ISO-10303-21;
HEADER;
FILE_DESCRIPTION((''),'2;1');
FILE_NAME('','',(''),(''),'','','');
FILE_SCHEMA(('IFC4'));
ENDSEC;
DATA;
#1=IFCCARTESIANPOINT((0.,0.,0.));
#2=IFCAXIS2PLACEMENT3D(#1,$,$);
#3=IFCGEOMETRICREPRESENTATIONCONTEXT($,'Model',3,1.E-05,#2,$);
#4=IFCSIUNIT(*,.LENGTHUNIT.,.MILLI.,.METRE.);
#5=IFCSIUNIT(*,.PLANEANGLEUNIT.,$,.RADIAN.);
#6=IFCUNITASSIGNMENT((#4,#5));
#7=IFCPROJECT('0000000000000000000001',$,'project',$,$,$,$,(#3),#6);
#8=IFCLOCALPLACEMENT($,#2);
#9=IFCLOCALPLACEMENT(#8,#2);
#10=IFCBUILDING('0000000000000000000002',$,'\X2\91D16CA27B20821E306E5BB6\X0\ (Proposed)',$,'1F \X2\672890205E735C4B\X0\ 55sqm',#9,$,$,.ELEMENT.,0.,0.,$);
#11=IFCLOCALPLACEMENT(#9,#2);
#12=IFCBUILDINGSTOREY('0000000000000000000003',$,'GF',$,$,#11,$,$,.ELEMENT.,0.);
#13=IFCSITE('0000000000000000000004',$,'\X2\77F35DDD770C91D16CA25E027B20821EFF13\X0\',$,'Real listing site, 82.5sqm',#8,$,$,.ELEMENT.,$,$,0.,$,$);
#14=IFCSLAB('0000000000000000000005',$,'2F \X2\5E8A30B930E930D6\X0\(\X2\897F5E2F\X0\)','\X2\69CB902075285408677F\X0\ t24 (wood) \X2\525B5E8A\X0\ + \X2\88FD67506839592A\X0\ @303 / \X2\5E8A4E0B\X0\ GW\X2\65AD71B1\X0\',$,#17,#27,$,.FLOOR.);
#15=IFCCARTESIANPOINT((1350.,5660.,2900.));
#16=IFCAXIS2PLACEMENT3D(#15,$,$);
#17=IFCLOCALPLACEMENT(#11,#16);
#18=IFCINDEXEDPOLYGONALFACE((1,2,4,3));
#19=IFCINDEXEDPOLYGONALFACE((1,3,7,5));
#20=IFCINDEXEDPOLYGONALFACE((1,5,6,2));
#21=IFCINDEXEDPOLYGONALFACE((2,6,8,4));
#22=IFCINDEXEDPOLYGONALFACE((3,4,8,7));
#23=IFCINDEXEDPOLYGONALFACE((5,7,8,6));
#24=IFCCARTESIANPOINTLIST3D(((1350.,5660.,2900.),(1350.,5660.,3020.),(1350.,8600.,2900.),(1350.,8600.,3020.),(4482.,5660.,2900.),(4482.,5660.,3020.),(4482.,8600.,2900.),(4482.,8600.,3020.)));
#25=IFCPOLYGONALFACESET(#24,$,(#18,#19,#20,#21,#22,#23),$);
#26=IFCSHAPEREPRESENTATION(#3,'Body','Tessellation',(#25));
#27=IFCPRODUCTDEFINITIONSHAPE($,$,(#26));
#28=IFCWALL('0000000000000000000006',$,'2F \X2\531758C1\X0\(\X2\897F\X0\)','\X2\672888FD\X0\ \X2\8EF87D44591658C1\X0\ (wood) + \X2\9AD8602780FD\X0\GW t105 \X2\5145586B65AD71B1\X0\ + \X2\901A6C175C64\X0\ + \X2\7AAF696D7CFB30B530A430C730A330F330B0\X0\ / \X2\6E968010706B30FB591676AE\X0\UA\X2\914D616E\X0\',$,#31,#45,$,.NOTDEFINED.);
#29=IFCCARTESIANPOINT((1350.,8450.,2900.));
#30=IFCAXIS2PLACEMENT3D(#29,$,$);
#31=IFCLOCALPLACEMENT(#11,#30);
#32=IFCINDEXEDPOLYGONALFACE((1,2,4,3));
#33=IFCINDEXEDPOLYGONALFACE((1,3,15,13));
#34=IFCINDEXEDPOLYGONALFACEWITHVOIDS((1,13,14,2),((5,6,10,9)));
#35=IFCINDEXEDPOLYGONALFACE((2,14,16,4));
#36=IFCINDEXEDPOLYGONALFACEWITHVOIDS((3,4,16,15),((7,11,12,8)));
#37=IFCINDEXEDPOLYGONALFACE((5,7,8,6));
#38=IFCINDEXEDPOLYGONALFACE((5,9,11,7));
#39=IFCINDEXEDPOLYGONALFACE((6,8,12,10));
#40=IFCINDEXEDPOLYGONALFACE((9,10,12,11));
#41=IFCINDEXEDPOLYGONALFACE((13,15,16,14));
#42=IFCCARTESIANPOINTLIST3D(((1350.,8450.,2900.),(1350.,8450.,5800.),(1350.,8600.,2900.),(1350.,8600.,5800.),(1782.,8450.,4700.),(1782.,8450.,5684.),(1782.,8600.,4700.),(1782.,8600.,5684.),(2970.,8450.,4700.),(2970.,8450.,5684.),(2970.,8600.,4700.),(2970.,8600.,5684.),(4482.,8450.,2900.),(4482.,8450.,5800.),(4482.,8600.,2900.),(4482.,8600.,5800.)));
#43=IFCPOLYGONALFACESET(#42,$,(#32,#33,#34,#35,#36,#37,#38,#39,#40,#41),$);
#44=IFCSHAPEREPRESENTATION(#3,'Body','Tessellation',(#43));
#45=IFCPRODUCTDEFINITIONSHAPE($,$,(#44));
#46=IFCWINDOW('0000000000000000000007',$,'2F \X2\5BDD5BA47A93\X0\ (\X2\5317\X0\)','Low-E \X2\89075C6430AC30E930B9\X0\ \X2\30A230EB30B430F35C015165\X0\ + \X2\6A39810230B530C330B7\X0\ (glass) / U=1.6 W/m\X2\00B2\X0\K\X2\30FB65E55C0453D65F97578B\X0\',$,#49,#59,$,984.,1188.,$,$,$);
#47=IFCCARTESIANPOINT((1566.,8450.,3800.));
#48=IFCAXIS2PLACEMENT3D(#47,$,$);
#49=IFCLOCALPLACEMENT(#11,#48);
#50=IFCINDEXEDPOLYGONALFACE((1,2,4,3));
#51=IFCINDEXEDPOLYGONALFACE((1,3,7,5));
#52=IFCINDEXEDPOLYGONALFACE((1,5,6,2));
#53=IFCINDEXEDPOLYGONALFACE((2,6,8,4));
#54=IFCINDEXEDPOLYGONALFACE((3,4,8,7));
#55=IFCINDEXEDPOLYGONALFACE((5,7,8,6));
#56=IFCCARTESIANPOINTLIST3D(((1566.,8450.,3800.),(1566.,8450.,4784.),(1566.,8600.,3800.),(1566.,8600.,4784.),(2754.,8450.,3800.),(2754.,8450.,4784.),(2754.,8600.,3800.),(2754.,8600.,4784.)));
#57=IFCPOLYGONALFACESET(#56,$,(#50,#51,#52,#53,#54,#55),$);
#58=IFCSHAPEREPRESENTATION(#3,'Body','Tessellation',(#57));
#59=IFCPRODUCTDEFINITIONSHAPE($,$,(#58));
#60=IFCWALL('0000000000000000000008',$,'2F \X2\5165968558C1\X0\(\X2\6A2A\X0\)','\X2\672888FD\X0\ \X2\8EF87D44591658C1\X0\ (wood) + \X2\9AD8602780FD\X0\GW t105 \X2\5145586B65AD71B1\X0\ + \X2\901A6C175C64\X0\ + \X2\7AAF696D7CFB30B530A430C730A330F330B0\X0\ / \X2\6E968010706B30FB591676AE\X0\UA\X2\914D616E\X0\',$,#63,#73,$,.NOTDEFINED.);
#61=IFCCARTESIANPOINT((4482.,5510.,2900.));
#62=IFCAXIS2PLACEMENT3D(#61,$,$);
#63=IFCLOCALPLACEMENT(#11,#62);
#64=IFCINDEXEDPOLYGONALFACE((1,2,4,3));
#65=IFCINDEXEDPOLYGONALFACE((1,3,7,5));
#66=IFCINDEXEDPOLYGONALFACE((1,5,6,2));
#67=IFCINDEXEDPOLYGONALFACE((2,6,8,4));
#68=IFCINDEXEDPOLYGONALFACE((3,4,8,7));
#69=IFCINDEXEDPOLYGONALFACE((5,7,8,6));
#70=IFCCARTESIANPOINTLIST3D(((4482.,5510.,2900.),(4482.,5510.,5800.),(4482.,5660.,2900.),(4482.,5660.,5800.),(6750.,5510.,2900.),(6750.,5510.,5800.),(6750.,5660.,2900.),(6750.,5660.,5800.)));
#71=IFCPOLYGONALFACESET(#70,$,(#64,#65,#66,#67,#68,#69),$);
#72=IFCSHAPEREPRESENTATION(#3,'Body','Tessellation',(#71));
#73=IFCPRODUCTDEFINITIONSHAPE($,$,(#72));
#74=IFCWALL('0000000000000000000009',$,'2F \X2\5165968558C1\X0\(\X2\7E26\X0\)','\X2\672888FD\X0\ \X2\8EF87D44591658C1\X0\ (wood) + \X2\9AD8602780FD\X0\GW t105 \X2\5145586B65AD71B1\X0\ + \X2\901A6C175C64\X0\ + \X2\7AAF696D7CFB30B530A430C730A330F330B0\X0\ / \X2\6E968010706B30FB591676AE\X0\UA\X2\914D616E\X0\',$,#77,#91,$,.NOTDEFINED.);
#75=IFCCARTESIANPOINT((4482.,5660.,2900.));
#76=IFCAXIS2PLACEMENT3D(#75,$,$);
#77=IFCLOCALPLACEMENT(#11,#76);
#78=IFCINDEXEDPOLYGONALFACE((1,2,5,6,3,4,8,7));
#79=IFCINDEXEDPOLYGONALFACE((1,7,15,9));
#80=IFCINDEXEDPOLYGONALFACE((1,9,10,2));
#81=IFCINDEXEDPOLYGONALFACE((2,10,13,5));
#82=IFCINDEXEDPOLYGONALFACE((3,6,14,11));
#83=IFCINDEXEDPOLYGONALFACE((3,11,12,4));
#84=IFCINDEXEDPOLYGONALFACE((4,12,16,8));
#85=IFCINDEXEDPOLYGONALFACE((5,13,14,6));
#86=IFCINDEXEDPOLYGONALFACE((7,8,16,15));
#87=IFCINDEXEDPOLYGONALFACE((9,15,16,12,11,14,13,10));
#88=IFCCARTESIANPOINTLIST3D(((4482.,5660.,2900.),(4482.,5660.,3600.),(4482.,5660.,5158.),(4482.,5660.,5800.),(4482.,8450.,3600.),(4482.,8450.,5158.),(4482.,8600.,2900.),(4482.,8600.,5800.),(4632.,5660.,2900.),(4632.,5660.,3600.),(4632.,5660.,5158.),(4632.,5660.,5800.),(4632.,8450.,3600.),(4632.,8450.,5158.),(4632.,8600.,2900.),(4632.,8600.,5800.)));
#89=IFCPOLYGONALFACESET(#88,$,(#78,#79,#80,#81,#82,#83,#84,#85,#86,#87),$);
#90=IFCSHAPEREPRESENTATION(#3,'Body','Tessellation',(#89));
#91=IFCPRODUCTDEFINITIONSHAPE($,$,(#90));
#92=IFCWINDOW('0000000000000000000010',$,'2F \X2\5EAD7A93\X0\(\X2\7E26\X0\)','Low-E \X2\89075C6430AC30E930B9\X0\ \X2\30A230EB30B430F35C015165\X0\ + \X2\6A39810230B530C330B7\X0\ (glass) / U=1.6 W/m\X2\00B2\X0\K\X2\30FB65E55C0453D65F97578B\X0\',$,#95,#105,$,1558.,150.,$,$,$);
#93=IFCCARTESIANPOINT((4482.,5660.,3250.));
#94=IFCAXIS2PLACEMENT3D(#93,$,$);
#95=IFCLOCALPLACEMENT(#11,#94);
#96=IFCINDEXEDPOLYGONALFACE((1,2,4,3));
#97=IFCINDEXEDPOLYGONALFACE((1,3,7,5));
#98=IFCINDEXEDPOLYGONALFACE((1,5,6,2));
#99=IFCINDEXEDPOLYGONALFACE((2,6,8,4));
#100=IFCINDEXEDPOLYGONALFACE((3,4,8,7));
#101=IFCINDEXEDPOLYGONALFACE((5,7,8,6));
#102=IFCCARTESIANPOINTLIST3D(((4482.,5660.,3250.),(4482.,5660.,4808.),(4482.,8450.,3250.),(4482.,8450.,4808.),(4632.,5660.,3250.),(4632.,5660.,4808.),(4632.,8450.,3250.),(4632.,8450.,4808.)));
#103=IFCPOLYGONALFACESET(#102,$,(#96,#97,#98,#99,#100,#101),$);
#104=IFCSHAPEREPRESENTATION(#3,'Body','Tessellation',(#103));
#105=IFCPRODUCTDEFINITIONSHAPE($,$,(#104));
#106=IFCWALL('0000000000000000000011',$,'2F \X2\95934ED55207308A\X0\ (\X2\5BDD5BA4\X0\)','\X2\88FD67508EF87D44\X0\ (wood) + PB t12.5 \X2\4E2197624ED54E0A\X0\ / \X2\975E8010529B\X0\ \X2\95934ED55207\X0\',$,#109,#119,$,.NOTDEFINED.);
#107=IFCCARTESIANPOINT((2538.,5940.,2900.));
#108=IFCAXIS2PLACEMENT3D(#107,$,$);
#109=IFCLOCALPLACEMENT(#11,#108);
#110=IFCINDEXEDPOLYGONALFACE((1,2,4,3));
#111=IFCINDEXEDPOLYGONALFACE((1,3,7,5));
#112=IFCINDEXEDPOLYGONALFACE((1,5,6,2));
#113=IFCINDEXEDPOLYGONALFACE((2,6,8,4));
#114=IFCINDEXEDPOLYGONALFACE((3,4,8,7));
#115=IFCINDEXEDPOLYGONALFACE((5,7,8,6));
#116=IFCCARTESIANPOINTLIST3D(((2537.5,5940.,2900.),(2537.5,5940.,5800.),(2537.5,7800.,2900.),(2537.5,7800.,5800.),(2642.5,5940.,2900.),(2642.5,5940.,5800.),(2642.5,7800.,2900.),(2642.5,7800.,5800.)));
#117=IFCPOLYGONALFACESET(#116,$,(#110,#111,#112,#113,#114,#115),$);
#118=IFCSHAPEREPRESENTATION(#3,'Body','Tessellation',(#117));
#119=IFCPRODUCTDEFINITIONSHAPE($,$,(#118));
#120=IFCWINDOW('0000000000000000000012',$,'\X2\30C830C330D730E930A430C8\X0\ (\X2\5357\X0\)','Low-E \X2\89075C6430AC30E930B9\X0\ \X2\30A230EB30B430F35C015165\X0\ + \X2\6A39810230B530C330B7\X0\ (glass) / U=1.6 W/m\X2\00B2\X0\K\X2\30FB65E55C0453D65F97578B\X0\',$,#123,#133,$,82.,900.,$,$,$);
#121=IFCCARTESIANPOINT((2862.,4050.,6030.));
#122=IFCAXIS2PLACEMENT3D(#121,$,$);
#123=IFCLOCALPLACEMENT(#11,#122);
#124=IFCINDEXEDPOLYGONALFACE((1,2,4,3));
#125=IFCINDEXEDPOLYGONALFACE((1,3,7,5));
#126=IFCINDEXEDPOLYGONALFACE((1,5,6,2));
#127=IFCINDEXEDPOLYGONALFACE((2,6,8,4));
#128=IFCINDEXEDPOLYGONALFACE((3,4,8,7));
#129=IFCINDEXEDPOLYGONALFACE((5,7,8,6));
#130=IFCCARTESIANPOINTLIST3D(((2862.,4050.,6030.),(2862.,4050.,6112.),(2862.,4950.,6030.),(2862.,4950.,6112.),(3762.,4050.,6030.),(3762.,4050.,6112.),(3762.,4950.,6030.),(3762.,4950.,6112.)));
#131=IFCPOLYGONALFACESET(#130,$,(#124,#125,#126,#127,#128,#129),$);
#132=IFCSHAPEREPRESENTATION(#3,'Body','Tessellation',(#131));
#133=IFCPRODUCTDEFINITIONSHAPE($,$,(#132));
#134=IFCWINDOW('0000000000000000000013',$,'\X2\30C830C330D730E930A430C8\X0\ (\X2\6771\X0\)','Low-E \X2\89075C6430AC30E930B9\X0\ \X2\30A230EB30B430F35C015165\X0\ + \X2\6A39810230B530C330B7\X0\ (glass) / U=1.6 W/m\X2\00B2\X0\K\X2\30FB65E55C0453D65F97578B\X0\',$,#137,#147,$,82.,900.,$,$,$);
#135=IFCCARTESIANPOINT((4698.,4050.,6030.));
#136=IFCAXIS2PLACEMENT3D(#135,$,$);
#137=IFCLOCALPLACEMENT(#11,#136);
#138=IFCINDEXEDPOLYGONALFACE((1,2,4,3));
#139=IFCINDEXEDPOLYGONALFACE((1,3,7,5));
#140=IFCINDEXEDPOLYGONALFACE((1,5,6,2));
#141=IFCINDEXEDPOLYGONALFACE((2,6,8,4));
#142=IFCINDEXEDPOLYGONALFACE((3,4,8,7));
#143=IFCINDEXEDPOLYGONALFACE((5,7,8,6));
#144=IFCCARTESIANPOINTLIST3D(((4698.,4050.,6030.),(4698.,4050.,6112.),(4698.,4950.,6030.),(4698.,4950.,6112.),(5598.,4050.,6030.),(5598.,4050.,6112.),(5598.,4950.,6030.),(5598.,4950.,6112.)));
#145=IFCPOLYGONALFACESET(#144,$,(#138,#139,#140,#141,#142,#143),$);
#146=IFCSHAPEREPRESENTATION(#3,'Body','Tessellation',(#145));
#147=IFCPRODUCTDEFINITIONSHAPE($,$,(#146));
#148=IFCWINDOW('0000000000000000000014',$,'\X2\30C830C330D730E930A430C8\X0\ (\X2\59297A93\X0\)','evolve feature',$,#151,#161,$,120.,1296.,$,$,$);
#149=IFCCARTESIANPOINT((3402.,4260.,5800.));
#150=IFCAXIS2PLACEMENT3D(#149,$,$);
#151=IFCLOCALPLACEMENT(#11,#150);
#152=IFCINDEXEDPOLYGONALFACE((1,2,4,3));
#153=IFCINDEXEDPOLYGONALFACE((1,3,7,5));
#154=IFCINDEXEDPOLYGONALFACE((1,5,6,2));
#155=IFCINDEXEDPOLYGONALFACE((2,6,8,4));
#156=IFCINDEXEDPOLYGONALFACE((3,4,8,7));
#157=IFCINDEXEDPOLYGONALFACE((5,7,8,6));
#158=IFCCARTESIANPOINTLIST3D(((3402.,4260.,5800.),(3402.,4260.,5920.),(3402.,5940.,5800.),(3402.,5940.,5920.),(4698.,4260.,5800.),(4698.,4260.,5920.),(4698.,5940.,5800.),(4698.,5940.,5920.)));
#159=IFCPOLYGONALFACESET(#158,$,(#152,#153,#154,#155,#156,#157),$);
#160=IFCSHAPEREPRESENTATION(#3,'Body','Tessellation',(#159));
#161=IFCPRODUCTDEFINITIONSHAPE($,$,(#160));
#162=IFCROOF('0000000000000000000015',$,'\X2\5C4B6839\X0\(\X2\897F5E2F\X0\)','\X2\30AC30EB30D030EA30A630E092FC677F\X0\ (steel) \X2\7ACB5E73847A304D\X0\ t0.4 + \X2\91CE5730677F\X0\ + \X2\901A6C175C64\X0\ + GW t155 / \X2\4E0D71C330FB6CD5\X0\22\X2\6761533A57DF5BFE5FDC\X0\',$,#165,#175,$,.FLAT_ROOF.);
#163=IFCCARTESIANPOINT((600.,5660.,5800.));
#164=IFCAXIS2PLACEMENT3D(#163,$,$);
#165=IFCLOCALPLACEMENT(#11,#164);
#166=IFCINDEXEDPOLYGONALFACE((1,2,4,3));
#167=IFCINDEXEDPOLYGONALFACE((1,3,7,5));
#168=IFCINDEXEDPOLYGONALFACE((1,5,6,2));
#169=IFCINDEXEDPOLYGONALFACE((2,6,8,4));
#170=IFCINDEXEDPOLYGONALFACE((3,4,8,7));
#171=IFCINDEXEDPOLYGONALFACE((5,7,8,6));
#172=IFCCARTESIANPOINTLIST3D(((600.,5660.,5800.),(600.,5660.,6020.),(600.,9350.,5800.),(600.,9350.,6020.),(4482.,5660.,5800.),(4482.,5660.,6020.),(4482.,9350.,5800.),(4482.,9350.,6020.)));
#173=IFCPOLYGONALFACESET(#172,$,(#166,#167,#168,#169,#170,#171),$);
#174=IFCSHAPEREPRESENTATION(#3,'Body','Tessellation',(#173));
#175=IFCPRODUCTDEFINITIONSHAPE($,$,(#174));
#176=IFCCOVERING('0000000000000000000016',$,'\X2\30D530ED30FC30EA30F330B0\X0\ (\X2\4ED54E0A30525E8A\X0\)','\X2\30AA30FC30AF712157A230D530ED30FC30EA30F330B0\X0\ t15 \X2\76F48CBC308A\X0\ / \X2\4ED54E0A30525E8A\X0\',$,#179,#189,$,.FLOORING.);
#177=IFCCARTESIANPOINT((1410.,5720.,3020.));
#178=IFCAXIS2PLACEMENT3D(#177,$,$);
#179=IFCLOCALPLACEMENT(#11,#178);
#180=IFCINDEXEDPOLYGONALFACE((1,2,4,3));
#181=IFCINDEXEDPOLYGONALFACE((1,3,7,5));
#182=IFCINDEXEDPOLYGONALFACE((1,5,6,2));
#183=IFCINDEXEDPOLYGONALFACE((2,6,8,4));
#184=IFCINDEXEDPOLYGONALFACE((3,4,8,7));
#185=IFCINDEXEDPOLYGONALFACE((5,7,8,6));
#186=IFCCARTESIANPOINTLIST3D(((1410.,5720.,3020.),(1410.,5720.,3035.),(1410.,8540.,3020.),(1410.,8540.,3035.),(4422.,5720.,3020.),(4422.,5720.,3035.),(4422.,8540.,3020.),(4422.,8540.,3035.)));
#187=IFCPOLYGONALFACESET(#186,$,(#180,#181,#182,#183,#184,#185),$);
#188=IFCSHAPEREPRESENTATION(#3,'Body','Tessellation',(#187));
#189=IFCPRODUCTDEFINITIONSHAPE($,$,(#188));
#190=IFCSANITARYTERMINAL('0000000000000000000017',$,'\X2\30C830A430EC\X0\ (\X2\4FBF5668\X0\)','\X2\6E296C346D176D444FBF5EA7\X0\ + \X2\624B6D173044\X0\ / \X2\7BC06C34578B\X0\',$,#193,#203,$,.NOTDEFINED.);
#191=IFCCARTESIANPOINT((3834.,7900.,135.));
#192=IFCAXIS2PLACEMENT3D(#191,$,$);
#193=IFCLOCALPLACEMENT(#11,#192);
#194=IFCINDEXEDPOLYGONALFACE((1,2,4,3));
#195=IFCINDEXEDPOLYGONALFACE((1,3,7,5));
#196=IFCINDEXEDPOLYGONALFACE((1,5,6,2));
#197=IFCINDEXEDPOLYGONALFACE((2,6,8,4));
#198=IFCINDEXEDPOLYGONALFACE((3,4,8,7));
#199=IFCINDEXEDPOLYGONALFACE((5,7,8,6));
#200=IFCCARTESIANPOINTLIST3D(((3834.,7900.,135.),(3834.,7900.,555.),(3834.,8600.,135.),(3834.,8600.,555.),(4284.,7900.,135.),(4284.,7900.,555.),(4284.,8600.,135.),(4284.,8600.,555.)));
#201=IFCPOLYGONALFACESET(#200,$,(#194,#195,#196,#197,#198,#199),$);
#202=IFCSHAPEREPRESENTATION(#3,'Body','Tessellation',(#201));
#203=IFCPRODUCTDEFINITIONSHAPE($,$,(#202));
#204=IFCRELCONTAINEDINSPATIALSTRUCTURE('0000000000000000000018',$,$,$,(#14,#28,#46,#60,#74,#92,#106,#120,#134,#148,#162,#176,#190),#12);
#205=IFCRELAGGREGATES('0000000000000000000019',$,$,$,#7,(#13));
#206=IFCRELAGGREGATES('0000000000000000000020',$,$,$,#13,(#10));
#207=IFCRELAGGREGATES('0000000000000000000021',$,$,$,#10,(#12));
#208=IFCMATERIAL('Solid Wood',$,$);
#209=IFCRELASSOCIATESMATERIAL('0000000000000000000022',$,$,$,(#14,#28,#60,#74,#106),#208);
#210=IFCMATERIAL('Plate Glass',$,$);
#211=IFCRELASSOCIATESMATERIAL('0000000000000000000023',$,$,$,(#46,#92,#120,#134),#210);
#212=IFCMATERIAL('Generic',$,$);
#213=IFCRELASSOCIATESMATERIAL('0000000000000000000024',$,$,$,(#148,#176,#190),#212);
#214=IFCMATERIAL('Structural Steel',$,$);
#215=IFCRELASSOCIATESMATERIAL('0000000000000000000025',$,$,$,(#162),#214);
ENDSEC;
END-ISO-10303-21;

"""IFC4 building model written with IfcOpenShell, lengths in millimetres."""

from ifc_helpers import new_model, si_unit, frame, frame_2d, origin, place, context, project, spatial, rectangle, extrude, material, element, fill, save


model = new_model("IFC4")

# Units and contexts
model_context = context("Model", 3, precision=1e-05, world=origin())
ifc_project = project(units=[si_unit("LENGTHUNIT", "METRE", prefix="MILLI"), si_unit("PLANEANGLEUNIT", "RADIAN")], contexts=[model_context])

# Site, building, storey
site_placement = place(None, origin())
site = spatial("IfcSite", under=ifc_project, at=site_placement, Name="石川県金沢市笠舞３", ObjectType="Real listing site, 82.5sqm", CompositionType="ELEMENT", RefElevation=0.0)
building_placement = place(site_placement, origin())
building = spatial("IfcBuilding", under=site, at=building_placement, Name="金沢笠舞の家 (Proposed)", ObjectType="1F 木造平屋 55sqm", CompositionType="ELEMENT", ElevationOfRefHeight=0.0, ElevationOfTerrain=0.0)
storey_placement = place(building_placement, origin())
storey = spatial("IfcBuildingStorey", under=building, at=storey_placement, Name="GF", CompositionType="ELEMENT", Elevation=0.0)

# Slab
ifc_material_1 = material(Name="Solid Wood")
slab_placement = place(storey_placement, frame((1350.0, 5660.0, 2900.0)))
element("IfcSlab", 1, at=slab_placement, inside=storey, material=ifc_material_1, Name="2F 床スラブ(西帯)", Description="構造用合板 t24 (wood) 剛床 + 製材根太 @303 / 床下 GW断熱", PredefinedType="FLOOR", context=model_context, shape_type="SweptSolid", body=[
    extrude(rectangle(XDim=3132.0, YDim=2940.0, at=frame_2d((1566.0, 1470.0))), frame((1350.0, 5660.0, 2900.0)), (0.0, 0.0, 1.0), 120.0),
])

# Wall, opening, window
wall_1_placement = place(storey_placement, frame((1350.0, 8450.0, 2900.0)))
wall_1 = element("IfcWall", 2, at=wall_1_placement, inside=storey, material=ifc_material_1, Name="2F 北壁(西)", Description="木製 軸組外壁 (wood) + 高性能GW t105 充填断熱 + 通気層 + 窯業系サイディング / 準耐火・外皮UA配慮", PredefinedType="NOTDEFINED", context=model_context, shape_type="SweptSolid", body=[
    extrude(rectangle(XDim=3132.0, YDim=150.0, at=frame_2d((1566.0, 75.0))), frame((1350.0, 8450.0, 2900.0)), (0.0, 0.0, 1.0), 2900.0),
])
opening_1_placement = place(storey_placement, frame((1566.0, 8450.0, 3800.0)))
opening_1 = element("IfcOpeningElement", 3, at=opening_1_placement, cuts=wall_1, PredefinedType="NOTDEFINED", context=model_context, shape_type="SweptSolid", body=[
    extrude(rectangle(XDim=1188.0, YDim=150.0, at=frame_2d((594.0, 75.0))), frame((1566.0, 8450.0, 3800.0)), (0.0, 0.0, 1.0), 984.0),
])
ifc_material_2 = material(Name="Plate Glass")
window_1_placement = place(storey_placement, frame((1566.0, 8450.0, 3800.0)))
window_1 = element("IfcWindow", 4, at=window_1_placement, inside=storey, material=ifc_material_2, Name="2F 寝室窓 (北)", Description="Low-E 複層ガラス アルゴン封入 + 樹脂サッシ (glass) / U=1.6 W/m²K・日射取得型", OverallHeight=984.0, OverallWidth=1188.0, context=model_context, shape_type="SweptSolid", body=[
    extrude(rectangle(XDim=1188.0, YDim=150.0, at=frame_2d((594.0, 75.0))), frame((1566.0, 8450.0, 3800.0)), (0.0, 0.0, 1.0), 984.0),
])
fill(opening_1, window_1)

# Wall
wall_2_placement = place(storey_placement, frame((4482.0, 5510.0, 2900.0)))
element("IfcWall", 5, at=wall_2_placement, inside=storey, material=ifc_material_1, Name="2F 入隅壁(横)", Description="木製 軸組外壁 (wood) + 高性能GW t105 充填断熱 + 通気層 + 窯業系サイディング / 準耐火・外皮UA配慮", PredefinedType="NOTDEFINED", context=model_context, shape_type="SweptSolid", body=[
    extrude(rectangle(XDim=2268.0, YDim=150.0, at=frame_2d((1134.0, 75.0))), frame((4482.0, 5510.0, 2900.0)), (0.0, 0.0, 1.0), 2900.0),
])

# Wall, opening, window
wall_3_placement = place(storey_placement, frame((4482.0, 5660.0, 2900.0)))
wall_3 = element("IfcWall", 6, at=wall_3_placement, inside=storey, material=ifc_material_1, Name="2F 入隅壁(縦)", Description="木製 軸組外壁 (wood) + 高性能GW t105 充填断熱 + 通気層 + 窯業系サイディング / 準耐火・外皮UA配慮", PredefinedType="NOTDEFINED", context=model_context, shape_type="SweptSolid", body=[
    extrude(rectangle(XDim=150.0, YDim=2940.0, at=frame_2d((75.0, 1470.0))), frame((4482.0, 5660.0, 2900.0)), (0.0, 0.0, 1.0), 2900.0),
])
opening_2_placement = place(storey_placement, frame((4482.0, 5660.0, 3250.0)))
opening_2 = element("IfcOpeningElement", 7, at=opening_2_placement, cuts=wall_3, PredefinedType="NOTDEFINED", context=model_context, shape_type="SweptSolid", body=[
    extrude(rectangle(XDim=150.0, YDim=2790.0, at=frame_2d((75.0, 1395.0))), frame((4482.0, 5660.0, 3250.0)), (0.0, 0.0, 1.0), 1558.0),
])
window_2_placement = place(storey_placement, frame((4482.0, 5660.0, 3250.0)))
window_2 = element("IfcWindow", 8, at=window_2_placement, inside=storey, material=ifc_material_2, Name="2F 庭窓(縦)", Description="Low-E 複層ガラス アルゴン封入 + 樹脂サッシ (glass) / U=1.6 W/m²K・日射取得型", OverallHeight=1558.0, OverallWidth=150.0, context=model_context, shape_type="SweptSolid", body=[
    extrude(rectangle(XDim=150.0, YDim=2790.0, at=frame_2d((75.0, 1395.0))), frame((4482.0, 5660.0, 3250.0)), (0.0, 0.0, 1.0), 1558.0),
])
fill(opening_2, window_2)

# Wall
wall_4_placement = place(storey_placement, frame((2538.0, 5940.0, 2900.0)))
element("IfcWall", 9, at=wall_4_placement, inside=storey, material=ifc_material_1, Name="2F 間仕切り (寝室)", Description="製材軸組 (wood) + PB t12.5 両面仕上 / 非耐力 間仕切", PredefinedType="NOTDEFINED", context=model_context, shape_type="SweptSolid", body=[
    extrude(rectangle(XDim=105.0, YDim=1860.0, at=frame_2d((52.0, 930.0))), frame((2538.0, 5940.0, 2900.0)), (0.0, 0.0, 1.0), 2900.0),
])

# Windows
window_3_placement = place(storey_placement, frame((2862.0, 4050.0, 6030.0)))
element("IfcWindow", 10, at=window_3_placement, inside=storey, material=ifc_material_2, Name="トップライト (南)", Description="Low-E 複層ガラス アルゴン封入 + 樹脂サッシ (glass) / U=1.6 W/m²K・日射取得型", OverallHeight=82.0, OverallWidth=900.0, context=model_context, shape_type="SweptSolid", body=[
    extrude(rectangle(XDim=900.0, YDim=900.0, at=frame_2d((450.0, 450.0))), frame((2862.0, 4050.0, 6030.0)), (0.0, 0.0, 1.0), 82.0),
])
window_4_placement = place(storey_placement, frame((4698.0, 4050.0, 6030.0)))
element("IfcWindow", 11, at=window_4_placement, inside=storey, material=ifc_material_2, Name="トップライト (東)", Description="Low-E 複層ガラス アルゴン封入 + 樹脂サッシ (glass) / U=1.6 W/m²K・日射取得型", OverallHeight=82.0, OverallWidth=900.0, context=model_context, shape_type="SweptSolid", body=[
    extrude(rectangle(XDim=900.0, YDim=900.0, at=frame_2d((450.0, 450.0))), frame((4698.0, 4050.0, 6030.0)), (0.0, 0.0, 1.0), 82.0),
])
ifc_material_3 = material(Name="Generic")
window_5_placement = place(storey_placement, frame((3402.0, 4260.0, 5800.0)))
element("IfcWindow", 12, at=window_5_placement, inside=storey, material=ifc_material_3, Name="トップライト (天窓)", Description="evolve feature", OverallHeight=120.0, OverallWidth=1296.0, context=model_context, shape_type="SweptSolid", body=[
    extrude(rectangle(XDim=1296.0, YDim=1680.0, at=frame_2d((648.0, 840.0))), frame((3402.0, 4260.0, 5800.0)), (0.0, 0.0, 1.0), 120.0),
])

# Roof
ifc_material_4 = material(Name="Structural Steel")
for number, where, name in (
    (13, (600.0, 5660.0, 5800.0), "屋根(西帯)"),
):
    element("IfcRoof", number, at=place(storey_placement, frame(where)), inside=storey, material=ifc_material_4, Name=name, Description="ガルバリウム鋼板 (steel) 立平葺き t0.4 + 野地板 + 通気層 + GW t155 / 不燃・法22条区域対応", PredefinedType="FLAT_ROOF", context=model_context, shape_type="SweptSolid", body=[
        extrude(rectangle(XDim=3882.0, YDim=3690.0, at=frame_2d((1941.0, 1845.0))), frame((600.0, 5660.0, 5800.0)), (0.0, 0.0, 1.0), 220.0),
    ])

# Covering
covering_placement = place(storey_placement, frame((1410.0, 5720.0, 3020.0)))
element("IfcCovering", 14, at=covering_placement, inside=storey, material=ifc_material_3, Name="フローリング (仕上げ床)", Description="オーク無垢フローリング t15 直貼り / 仕上げ床", PredefinedType="FLOORING", context=model_context, shape_type="SweptSolid", body=[
    extrude(rectangle(XDim=3012.0, YDim=2820.0, at=frame_2d((1506.0, 1410.0))), frame((1410.0, 5720.0, 3020.0)), (0.0, 0.0, 1.0), 15.0),
])

# Sanitary terminal
sanitary_terminal_placement = place(storey_placement, frame((3834.0, 7900.0, 135.0)))
element("IfcSanitaryTerminal", 15, at=sanitary_terminal_placement, inside=storey, material=ifc_material_3, Name="トイレ (便器)", Description="温水洗浄便座 + 手洗い / 節水型", PredefinedType="NOTDEFINED", context=model_context, shape_type="SweptSolid", body=[
    extrude(rectangle(XDim=450.0, YDim=700.0, at=frame_2d((225.0, 350.0))), frame((3834.0, 7900.0, 135.0)), (0.0, 0.0, 1.0), 420.0),
])

save(model, "model.ifc")
